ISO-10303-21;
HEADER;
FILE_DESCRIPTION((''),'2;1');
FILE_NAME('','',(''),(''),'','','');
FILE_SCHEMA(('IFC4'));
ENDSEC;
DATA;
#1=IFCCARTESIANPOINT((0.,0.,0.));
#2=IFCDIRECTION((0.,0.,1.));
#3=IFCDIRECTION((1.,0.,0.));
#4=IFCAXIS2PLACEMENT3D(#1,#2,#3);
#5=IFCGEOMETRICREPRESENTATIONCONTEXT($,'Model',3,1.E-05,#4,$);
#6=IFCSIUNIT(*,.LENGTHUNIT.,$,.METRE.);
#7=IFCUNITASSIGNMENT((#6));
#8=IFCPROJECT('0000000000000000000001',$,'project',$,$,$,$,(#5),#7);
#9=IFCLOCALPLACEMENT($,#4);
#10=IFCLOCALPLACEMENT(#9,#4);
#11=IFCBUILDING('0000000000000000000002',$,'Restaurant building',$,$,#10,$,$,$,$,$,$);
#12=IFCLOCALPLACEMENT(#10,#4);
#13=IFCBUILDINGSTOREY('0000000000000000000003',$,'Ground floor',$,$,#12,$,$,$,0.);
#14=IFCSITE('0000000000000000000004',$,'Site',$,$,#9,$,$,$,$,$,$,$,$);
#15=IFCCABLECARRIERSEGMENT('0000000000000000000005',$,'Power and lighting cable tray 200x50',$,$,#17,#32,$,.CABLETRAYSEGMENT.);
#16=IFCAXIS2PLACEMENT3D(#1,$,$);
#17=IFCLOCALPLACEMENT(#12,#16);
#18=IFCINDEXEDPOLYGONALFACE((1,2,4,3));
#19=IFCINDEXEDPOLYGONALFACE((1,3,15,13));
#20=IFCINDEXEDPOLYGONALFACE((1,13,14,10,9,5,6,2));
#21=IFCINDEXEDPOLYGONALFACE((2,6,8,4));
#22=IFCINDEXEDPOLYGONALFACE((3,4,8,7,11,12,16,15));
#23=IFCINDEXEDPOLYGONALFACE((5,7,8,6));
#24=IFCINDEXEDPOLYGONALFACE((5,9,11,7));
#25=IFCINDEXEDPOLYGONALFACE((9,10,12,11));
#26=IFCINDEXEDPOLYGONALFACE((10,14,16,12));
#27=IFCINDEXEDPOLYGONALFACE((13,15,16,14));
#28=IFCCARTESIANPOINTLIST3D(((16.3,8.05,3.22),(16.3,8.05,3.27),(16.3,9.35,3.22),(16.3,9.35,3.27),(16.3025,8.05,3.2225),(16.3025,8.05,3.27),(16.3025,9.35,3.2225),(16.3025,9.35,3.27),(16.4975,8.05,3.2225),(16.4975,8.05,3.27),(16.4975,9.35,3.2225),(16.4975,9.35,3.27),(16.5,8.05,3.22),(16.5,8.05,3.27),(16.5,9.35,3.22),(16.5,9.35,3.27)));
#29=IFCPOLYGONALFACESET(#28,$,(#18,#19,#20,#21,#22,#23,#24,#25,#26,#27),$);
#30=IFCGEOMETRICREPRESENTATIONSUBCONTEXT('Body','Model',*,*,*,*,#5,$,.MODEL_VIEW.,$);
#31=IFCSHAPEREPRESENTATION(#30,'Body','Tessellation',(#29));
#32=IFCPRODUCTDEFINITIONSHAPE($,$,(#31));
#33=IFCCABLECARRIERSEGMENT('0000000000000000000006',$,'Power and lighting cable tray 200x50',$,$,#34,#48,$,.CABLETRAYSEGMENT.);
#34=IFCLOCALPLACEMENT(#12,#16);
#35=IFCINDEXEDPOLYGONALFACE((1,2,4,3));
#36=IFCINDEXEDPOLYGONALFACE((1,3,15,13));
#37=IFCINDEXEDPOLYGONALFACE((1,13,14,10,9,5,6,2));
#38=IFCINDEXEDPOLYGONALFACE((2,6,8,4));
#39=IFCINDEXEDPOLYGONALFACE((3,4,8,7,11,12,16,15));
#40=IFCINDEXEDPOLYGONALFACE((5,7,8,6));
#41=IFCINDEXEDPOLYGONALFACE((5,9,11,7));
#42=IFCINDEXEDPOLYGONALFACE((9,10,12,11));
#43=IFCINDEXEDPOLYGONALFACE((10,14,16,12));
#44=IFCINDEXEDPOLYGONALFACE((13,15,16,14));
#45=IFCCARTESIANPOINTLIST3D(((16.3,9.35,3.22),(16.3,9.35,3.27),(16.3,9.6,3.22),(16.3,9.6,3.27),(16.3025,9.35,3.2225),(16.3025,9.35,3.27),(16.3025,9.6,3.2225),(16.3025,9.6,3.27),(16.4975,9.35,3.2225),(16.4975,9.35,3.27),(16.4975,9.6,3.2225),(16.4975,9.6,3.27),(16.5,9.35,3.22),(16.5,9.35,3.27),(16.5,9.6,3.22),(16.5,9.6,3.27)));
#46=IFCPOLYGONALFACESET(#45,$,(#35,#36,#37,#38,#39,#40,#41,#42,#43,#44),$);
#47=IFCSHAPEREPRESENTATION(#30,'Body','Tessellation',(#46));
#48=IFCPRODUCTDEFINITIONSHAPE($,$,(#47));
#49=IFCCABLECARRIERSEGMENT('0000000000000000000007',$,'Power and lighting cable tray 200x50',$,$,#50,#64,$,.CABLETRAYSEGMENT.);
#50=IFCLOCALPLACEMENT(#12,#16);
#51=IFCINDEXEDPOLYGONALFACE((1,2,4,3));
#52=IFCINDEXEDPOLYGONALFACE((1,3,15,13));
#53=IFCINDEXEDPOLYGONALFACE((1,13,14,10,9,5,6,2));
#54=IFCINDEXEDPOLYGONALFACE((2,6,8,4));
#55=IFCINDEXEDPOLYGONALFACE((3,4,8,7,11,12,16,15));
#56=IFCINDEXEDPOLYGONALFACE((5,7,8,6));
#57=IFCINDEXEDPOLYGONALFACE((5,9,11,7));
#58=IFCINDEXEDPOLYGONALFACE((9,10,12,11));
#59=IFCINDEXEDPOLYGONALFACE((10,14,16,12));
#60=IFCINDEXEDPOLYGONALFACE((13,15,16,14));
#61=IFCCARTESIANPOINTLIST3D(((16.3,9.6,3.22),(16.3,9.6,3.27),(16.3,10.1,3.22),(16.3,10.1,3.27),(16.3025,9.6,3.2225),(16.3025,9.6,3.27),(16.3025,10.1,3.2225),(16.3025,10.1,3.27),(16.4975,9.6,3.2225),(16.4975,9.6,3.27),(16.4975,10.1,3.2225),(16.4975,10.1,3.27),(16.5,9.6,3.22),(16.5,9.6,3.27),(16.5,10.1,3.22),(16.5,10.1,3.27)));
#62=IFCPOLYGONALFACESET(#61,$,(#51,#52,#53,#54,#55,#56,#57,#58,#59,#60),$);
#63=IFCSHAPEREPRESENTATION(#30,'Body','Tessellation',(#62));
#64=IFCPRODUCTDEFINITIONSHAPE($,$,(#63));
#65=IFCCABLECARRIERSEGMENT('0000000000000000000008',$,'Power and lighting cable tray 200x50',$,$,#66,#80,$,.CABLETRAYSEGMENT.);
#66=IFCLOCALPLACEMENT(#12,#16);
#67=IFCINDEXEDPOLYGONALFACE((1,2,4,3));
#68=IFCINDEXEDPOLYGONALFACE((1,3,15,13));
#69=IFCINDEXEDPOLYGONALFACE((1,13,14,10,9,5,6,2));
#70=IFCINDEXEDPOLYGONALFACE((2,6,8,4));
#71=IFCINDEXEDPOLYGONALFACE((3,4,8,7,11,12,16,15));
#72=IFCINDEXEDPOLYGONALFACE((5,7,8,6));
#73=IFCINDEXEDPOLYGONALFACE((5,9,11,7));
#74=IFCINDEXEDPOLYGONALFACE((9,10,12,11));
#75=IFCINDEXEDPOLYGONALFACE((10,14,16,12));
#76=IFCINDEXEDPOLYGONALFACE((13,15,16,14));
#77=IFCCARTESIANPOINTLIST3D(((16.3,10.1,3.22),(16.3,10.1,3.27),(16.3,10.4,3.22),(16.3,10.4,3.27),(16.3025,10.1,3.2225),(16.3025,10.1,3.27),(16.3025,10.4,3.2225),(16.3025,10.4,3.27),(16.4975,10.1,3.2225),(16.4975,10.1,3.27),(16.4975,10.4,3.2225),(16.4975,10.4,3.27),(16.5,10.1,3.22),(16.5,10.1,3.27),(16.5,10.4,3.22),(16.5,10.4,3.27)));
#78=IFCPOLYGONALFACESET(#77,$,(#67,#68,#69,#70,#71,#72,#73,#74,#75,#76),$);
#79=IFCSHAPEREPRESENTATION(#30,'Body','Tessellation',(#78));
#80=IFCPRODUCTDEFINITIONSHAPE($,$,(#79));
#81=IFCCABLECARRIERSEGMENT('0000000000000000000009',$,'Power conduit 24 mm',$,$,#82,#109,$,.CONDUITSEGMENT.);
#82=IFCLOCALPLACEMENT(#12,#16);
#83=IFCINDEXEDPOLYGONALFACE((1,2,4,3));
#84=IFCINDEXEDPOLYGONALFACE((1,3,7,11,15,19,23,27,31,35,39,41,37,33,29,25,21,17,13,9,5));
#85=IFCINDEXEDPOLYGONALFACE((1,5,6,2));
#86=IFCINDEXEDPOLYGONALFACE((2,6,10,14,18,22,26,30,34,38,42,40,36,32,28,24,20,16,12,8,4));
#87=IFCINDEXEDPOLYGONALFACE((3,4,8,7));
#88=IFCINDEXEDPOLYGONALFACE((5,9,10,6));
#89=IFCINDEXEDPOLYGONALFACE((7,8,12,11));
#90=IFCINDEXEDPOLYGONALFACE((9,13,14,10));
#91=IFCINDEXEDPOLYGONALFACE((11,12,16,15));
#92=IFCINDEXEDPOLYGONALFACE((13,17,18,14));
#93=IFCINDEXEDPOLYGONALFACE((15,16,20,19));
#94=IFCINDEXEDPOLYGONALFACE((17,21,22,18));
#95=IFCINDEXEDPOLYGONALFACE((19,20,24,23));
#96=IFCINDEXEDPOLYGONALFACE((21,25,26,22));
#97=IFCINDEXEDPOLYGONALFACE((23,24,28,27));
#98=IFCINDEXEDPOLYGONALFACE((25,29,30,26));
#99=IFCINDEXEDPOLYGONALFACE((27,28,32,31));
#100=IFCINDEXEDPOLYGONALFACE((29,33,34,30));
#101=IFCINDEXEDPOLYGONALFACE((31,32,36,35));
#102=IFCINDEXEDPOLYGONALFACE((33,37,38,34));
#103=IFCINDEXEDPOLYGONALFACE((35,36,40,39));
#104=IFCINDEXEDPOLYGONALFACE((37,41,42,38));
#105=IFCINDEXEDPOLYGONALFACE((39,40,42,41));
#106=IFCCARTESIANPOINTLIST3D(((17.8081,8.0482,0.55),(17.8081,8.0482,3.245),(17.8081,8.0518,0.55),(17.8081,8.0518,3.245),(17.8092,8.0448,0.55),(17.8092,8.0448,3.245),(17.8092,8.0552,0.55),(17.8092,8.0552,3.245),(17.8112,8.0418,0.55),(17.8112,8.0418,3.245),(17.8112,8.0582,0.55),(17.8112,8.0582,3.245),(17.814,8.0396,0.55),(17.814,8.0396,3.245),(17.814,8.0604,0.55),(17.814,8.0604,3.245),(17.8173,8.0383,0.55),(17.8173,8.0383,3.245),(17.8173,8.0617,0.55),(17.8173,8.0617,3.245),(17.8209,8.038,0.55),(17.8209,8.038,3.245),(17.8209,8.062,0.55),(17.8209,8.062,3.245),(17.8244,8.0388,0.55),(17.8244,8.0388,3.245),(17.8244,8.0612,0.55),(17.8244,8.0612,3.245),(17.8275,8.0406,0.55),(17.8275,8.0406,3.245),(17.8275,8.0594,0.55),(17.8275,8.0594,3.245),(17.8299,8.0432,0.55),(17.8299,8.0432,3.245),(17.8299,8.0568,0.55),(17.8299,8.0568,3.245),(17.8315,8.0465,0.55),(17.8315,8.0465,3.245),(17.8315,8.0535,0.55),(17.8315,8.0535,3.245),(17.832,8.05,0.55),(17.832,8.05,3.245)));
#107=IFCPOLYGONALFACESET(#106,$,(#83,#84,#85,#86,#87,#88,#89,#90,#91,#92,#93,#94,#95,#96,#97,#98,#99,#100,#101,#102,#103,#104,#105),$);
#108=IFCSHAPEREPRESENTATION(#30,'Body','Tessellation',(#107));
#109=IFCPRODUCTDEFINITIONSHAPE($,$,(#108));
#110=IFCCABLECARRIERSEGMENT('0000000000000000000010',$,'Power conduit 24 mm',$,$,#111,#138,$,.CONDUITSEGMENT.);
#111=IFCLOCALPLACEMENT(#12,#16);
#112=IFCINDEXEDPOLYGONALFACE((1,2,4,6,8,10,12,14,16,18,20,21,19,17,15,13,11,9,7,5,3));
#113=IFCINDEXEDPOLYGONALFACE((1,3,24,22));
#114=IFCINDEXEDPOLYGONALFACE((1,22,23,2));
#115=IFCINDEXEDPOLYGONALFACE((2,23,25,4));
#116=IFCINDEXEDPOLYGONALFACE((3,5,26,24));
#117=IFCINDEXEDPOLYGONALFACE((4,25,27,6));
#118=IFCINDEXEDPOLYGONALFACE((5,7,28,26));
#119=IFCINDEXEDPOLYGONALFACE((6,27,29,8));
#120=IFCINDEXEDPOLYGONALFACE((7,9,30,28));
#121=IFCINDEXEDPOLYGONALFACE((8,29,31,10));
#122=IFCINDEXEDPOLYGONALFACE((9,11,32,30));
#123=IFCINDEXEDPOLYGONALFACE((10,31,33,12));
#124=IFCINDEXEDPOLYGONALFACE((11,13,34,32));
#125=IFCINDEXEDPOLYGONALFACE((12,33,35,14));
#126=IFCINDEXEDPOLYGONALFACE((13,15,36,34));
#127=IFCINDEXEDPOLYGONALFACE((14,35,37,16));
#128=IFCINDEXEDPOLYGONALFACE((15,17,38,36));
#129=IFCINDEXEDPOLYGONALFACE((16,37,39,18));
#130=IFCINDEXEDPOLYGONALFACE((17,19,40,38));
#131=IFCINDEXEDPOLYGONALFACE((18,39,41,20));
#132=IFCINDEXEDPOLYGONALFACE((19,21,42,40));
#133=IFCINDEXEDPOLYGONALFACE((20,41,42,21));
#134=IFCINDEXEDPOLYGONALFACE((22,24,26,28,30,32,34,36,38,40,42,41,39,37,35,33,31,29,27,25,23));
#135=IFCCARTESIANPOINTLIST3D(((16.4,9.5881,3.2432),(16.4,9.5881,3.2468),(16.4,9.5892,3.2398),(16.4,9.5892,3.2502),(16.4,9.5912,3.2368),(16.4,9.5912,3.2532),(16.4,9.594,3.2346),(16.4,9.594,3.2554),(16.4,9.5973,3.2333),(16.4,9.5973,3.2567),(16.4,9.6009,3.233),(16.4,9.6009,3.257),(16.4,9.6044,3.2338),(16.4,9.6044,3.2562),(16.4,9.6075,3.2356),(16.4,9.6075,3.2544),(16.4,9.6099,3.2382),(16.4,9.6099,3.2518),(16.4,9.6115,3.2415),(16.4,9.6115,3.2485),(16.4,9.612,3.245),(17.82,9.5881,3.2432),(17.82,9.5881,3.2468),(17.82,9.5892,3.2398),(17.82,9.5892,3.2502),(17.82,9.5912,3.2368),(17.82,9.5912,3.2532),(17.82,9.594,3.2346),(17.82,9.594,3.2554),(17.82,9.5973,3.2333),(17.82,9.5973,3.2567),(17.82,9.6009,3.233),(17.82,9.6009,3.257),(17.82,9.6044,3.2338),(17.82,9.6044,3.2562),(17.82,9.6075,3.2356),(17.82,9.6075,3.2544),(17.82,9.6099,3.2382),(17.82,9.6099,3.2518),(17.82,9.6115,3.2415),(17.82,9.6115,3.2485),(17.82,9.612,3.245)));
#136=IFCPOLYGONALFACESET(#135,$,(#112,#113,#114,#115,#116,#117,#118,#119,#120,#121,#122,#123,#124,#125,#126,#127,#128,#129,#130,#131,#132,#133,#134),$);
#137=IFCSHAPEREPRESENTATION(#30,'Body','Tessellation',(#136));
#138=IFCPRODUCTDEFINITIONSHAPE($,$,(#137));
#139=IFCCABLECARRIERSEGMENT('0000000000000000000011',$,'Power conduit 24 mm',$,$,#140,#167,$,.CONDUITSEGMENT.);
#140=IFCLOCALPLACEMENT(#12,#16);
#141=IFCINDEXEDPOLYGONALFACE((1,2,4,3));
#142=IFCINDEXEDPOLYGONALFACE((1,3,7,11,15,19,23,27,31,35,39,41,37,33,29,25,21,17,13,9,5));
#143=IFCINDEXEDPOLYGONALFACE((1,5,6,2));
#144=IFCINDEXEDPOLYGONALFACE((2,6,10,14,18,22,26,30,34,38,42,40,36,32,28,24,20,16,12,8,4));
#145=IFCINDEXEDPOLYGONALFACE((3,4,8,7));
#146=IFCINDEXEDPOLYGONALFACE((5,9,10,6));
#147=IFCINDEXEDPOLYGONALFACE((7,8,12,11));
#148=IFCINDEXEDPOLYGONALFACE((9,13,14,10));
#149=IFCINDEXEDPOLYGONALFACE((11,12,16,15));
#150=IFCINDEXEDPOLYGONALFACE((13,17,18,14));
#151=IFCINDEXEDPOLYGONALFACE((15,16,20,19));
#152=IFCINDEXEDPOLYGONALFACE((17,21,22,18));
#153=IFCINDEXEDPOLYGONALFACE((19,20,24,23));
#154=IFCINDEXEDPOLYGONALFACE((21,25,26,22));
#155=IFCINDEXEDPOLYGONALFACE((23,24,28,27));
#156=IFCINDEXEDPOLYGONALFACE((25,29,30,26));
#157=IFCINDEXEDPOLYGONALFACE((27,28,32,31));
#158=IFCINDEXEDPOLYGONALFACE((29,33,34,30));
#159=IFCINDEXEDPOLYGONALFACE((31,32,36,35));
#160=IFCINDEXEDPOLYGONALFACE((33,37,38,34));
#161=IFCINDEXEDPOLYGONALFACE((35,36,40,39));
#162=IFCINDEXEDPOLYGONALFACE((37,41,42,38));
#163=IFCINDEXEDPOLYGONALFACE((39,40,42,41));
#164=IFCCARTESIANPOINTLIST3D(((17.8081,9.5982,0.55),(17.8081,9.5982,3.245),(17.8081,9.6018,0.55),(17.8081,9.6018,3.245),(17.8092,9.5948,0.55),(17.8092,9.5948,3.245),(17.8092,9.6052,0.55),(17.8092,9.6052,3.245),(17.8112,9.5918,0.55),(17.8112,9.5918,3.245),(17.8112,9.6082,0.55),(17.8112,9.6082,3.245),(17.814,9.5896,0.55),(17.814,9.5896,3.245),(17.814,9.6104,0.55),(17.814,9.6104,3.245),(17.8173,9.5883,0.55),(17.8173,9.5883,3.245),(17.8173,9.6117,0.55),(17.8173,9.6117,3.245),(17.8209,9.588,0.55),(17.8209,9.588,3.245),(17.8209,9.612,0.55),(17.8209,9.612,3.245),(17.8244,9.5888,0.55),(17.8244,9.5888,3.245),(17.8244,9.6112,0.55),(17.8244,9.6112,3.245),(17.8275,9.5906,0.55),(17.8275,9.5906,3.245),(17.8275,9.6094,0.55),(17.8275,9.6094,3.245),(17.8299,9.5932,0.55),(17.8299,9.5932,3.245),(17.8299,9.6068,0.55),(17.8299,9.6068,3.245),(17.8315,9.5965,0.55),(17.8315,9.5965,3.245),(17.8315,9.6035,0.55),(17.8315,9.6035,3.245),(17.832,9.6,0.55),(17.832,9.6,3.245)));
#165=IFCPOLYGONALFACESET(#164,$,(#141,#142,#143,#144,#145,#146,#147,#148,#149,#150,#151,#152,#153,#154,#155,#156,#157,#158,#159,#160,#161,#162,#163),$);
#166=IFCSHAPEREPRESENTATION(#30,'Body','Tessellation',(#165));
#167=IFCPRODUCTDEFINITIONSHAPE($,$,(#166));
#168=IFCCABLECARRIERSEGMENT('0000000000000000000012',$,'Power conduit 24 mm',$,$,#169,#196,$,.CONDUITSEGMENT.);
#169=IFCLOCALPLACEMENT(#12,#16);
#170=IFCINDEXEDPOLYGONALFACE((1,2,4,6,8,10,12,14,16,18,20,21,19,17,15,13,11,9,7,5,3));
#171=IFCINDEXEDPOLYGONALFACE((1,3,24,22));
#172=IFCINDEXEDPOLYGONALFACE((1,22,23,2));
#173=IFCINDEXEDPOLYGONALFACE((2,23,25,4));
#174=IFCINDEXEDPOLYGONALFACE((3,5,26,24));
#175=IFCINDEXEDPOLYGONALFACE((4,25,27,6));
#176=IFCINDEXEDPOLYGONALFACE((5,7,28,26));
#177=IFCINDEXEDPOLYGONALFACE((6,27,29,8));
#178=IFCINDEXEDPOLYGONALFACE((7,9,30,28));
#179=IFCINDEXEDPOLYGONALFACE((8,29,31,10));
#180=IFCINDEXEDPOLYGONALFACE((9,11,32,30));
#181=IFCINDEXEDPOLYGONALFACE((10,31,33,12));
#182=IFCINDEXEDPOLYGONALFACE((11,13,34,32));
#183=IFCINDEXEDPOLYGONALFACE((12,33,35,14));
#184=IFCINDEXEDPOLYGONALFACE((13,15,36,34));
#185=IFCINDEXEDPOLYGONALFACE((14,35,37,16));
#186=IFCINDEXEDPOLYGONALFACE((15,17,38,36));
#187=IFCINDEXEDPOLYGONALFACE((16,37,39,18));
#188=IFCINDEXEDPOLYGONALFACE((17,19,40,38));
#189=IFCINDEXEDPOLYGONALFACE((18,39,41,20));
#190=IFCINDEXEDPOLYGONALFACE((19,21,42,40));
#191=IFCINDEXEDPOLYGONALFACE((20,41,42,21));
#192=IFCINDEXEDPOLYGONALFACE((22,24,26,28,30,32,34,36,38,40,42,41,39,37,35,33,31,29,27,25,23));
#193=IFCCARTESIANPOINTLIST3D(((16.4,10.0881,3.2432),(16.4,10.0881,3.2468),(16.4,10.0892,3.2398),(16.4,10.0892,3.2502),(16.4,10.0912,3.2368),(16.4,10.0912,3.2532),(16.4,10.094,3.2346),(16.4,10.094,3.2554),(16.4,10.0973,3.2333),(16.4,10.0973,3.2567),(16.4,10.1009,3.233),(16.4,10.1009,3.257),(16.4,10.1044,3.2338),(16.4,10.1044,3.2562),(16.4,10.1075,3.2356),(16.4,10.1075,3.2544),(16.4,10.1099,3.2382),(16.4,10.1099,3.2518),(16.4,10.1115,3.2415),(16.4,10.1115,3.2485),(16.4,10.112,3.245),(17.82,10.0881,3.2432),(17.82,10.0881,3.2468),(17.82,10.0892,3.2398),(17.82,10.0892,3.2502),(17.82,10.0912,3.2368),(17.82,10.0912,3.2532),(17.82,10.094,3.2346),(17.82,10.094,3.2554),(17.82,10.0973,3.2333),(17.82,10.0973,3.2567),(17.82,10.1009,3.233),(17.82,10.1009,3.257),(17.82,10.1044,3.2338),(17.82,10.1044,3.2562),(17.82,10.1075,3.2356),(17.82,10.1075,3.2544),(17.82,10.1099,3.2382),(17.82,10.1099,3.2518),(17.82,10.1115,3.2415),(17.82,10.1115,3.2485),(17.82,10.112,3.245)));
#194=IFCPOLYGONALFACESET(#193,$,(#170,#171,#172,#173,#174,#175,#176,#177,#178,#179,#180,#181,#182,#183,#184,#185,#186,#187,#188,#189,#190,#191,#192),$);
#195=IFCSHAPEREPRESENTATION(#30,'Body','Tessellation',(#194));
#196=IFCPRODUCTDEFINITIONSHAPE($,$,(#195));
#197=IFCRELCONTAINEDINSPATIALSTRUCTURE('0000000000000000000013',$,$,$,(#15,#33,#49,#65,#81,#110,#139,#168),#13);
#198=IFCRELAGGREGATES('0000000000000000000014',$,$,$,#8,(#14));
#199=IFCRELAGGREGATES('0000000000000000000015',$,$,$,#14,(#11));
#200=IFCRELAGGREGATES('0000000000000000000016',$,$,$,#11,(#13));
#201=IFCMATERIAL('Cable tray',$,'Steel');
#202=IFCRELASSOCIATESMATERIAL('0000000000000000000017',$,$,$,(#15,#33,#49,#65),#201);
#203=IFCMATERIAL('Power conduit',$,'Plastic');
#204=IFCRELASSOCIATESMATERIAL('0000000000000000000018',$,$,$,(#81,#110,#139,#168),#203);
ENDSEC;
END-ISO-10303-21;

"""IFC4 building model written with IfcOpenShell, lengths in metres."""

from ifc_helpers import new_model, si_unit, frame, origin_with_axes, origin_2d, place, context, subcontext, project, spatial, polyline, circle, outline, extrude, material, element, save


model = new_model("IFC4")

# Units and contexts
model_context = context("Model", 3, precision=1e-05, world=origin_with_axes())
body_context = subcontext(model_context, "Body", "Model", "MODEL_VIEW")
ifc_project = project(units=[si_unit("LENGTHUNIT", "METRE")], contexts=[model_context])

# Site, building, storey
site_placement = place(None, origin_with_axes())
site = spatial("IfcSite", under=ifc_project, at=site_placement, Name="Site")
building_placement = place(site_placement, origin_with_axes())
building = spatial("IfcBuilding", under=site, at=building_placement, Name="Restaurant building")
storey_placement = place(building_placement, origin_with_axes())
storey = spatial("IfcBuildingStorey", under=building, at=storey_placement, Name="Ground floor", Elevation=0.0)

# Cable carrier segments
ifc_material_1 = material(Name="Cable tray", Category="Steel")
cable_carrier_segment_1_placement = place(storey_placement, frame((16.4, 9.35, 3.245)))
element("IfcCableCarrierSegment", 1, at=cable_carrier_segment_1_placement, inside=storey, material=ifc_material_1, Name="Power and lighting cable tray 200x50", PredefinedType="CABLETRAYSEGMENT", context=body_context, shape_type="SweptSolid", body=[
    extrude(outline(polyline([(-0.1, -0.025), (0.1, -0.025), (0.1, 0.025), (0.0975, 0.025), (0.0975, -0.0225), (-0.0975, -0.0225), (-0.0975, 0.025), (-0.1, 0.025), (-0.1, -0.025)])), frame((0.0, 0.0, 0.0), z_axis=(0.0, -1.0, 0.0), x_axis=(1.0, 0.0, 0.0)), (0.0, 0.0, 1.0), 1.3),
])
cable_carrier_segment_2_placement = place(storey_placement, frame((16.4, 9.35, 3.245)))
element("IfcCableCarrierSegment", 2, at=cable_carrier_segment_2_placement, inside=storey, material=ifc_material_1, Name="Power and lighting cable tray 200x50", PredefinedType="CABLETRAYSEGMENT", context=body_context, shape_type="SweptSolid", body=[
    extrude(outline(polyline([(-0.1, -0.025), (0.1, -0.025), (0.1, 0.025), (0.0975, 0.025), (0.0975, -0.0225), (-0.0975, -0.0225), (-0.0975, 0.025), (-0.1, 0.025), (-0.1, -0.025)])), frame((0.0, 0.0, 0.0), z_axis=(0.0, 1.0, 0.0), x_axis=(-1.0, 0.0, 0.0)), (0.0, 0.0, 1.0), 0.25),
])
cable_carrier_segment_3_placement = place(storey_placement, frame((16.4, 9.6, 3.245)))
element("IfcCableCarrierSegment", 3, at=cable_carrier_segment_3_placement, inside=storey, material=ifc_material_1, Name="Power and lighting cable tray 200x50", PredefinedType="CABLETRAYSEGMENT", context=body_context, shape_type="SweptSolid", body=[
    extrude(outline(polyline([(-0.1, -0.025), (0.1, -0.025), (0.1, 0.025), (0.0975, 0.025), (0.0975, -0.0225), (-0.0975, -0.0225), (-0.0975, 0.025), (-0.1, 0.025), (-0.1, -0.025)])), frame((0.0, 0.0, 0.0), z_axis=(0.0, 1.0, 0.0), x_axis=(-1.0, 0.0, 0.0)), (0.0, 0.0, 1.0), 0.5),
])
cable_carrier_segment_4_placement = place(storey_placement, frame((16.4, 10.1, 3.245)))
element("IfcCableCarrierSegment", 4, at=cable_carrier_segment_4_placement, inside=storey, material=ifc_material_1, Name="Power and lighting cable tray 200x50", PredefinedType="CABLETRAYSEGMENT", context=body_context, shape_type="SweptSolid", body=[
    extrude(outline(polyline([(-0.1, -0.025), (0.1, -0.025), (0.1, 0.025), (0.0975, 0.025), (0.0975, -0.0225), (-0.0975, -0.0225), (-0.0975, 0.025), (-0.1, 0.025), (-0.1, -0.025)])), frame((0.0, 0.0, 0.0), z_axis=(0.0, 1.0, 0.0), x_axis=(-1.0, 0.0, 0.0)), (0.0, 0.0, 1.0), 0.3),
])
ifc_material_2 = material(Name="Power conduit", Category="Plastic")
cable_carrier_segment_5_placement = place(storey_placement, frame((17.82, 8.05, 3.245)))
element("IfcCableCarrierSegment", 5, at=cable_carrier_segment_5_placement, inside=storey, material=ifc_material_2, Name="Power conduit 24 mm", PredefinedType="CONDUITSEGMENT", context=body_context, shape_type="SweptSolid", body=[
    extrude(circle(Radius=0.012, at=origin_2d()), frame((0.0, 0.0, 0.0), z_axis=(0.0, 0.0, -1.0), x_axis=(1.0, 0.0, 0.0)), (0.0, 0.0, 1.0), 2.695),
])
cable_carrier_segment_6_placement = place(storey_placement, frame((16.4, 9.6, 3.245)))
element("IfcCableCarrierSegment", 6, at=cable_carrier_segment_6_placement, inside=storey, material=ifc_material_2, Name="Power conduit 24 mm", PredefinedType="CONDUITSEGMENT", context=body_context, shape_type="SweptSolid", body=[
    extrude(circle(Radius=0.012, at=origin_2d()), frame((0.0, 0.0, 0.0), z_axis=(1.0, 0.0, 0.0), x_axis=(0.0, 1.0, 0.0)), (0.0, 0.0, 1.0), 1.42),
])
cable_carrier_segment_7_placement = place(storey_placement, frame((17.82, 9.6, 3.245)))
element("IfcCableCarrierSegment", 7, at=cable_carrier_segment_7_placement, inside=storey, material=ifc_material_2, Name="Power conduit 24 mm", PredefinedType="CONDUITSEGMENT", context=body_context, shape_type="SweptSolid", body=[
    extrude(circle(Radius=0.012, at=origin_2d()), frame((0.0, 0.0, 0.0), z_axis=(0.0, 0.0, -1.0), x_axis=(1.0, 0.0, 0.0)), (0.0, 0.0, 1.0), 2.695),
])
cable_carrier_segment_8_placement = place(storey_placement, frame((16.4, 10.1, 3.245)))
element("IfcCableCarrierSegment", 8, at=cable_carrier_segment_8_placement, inside=storey, material=ifc_material_2, Name="Power conduit 24 mm", PredefinedType="CONDUITSEGMENT", context=body_context, shape_type="SweptSolid", body=[
    extrude(circle(Radius=0.012, at=origin_2d()), frame((0.0, 0.0, 0.0), z_axis=(1.0, 0.0, 0.0), x_axis=(0.0, 1.0, 0.0)), (0.0, 0.0, 1.0), 1.42),
])

save(model, "model.ifc")
